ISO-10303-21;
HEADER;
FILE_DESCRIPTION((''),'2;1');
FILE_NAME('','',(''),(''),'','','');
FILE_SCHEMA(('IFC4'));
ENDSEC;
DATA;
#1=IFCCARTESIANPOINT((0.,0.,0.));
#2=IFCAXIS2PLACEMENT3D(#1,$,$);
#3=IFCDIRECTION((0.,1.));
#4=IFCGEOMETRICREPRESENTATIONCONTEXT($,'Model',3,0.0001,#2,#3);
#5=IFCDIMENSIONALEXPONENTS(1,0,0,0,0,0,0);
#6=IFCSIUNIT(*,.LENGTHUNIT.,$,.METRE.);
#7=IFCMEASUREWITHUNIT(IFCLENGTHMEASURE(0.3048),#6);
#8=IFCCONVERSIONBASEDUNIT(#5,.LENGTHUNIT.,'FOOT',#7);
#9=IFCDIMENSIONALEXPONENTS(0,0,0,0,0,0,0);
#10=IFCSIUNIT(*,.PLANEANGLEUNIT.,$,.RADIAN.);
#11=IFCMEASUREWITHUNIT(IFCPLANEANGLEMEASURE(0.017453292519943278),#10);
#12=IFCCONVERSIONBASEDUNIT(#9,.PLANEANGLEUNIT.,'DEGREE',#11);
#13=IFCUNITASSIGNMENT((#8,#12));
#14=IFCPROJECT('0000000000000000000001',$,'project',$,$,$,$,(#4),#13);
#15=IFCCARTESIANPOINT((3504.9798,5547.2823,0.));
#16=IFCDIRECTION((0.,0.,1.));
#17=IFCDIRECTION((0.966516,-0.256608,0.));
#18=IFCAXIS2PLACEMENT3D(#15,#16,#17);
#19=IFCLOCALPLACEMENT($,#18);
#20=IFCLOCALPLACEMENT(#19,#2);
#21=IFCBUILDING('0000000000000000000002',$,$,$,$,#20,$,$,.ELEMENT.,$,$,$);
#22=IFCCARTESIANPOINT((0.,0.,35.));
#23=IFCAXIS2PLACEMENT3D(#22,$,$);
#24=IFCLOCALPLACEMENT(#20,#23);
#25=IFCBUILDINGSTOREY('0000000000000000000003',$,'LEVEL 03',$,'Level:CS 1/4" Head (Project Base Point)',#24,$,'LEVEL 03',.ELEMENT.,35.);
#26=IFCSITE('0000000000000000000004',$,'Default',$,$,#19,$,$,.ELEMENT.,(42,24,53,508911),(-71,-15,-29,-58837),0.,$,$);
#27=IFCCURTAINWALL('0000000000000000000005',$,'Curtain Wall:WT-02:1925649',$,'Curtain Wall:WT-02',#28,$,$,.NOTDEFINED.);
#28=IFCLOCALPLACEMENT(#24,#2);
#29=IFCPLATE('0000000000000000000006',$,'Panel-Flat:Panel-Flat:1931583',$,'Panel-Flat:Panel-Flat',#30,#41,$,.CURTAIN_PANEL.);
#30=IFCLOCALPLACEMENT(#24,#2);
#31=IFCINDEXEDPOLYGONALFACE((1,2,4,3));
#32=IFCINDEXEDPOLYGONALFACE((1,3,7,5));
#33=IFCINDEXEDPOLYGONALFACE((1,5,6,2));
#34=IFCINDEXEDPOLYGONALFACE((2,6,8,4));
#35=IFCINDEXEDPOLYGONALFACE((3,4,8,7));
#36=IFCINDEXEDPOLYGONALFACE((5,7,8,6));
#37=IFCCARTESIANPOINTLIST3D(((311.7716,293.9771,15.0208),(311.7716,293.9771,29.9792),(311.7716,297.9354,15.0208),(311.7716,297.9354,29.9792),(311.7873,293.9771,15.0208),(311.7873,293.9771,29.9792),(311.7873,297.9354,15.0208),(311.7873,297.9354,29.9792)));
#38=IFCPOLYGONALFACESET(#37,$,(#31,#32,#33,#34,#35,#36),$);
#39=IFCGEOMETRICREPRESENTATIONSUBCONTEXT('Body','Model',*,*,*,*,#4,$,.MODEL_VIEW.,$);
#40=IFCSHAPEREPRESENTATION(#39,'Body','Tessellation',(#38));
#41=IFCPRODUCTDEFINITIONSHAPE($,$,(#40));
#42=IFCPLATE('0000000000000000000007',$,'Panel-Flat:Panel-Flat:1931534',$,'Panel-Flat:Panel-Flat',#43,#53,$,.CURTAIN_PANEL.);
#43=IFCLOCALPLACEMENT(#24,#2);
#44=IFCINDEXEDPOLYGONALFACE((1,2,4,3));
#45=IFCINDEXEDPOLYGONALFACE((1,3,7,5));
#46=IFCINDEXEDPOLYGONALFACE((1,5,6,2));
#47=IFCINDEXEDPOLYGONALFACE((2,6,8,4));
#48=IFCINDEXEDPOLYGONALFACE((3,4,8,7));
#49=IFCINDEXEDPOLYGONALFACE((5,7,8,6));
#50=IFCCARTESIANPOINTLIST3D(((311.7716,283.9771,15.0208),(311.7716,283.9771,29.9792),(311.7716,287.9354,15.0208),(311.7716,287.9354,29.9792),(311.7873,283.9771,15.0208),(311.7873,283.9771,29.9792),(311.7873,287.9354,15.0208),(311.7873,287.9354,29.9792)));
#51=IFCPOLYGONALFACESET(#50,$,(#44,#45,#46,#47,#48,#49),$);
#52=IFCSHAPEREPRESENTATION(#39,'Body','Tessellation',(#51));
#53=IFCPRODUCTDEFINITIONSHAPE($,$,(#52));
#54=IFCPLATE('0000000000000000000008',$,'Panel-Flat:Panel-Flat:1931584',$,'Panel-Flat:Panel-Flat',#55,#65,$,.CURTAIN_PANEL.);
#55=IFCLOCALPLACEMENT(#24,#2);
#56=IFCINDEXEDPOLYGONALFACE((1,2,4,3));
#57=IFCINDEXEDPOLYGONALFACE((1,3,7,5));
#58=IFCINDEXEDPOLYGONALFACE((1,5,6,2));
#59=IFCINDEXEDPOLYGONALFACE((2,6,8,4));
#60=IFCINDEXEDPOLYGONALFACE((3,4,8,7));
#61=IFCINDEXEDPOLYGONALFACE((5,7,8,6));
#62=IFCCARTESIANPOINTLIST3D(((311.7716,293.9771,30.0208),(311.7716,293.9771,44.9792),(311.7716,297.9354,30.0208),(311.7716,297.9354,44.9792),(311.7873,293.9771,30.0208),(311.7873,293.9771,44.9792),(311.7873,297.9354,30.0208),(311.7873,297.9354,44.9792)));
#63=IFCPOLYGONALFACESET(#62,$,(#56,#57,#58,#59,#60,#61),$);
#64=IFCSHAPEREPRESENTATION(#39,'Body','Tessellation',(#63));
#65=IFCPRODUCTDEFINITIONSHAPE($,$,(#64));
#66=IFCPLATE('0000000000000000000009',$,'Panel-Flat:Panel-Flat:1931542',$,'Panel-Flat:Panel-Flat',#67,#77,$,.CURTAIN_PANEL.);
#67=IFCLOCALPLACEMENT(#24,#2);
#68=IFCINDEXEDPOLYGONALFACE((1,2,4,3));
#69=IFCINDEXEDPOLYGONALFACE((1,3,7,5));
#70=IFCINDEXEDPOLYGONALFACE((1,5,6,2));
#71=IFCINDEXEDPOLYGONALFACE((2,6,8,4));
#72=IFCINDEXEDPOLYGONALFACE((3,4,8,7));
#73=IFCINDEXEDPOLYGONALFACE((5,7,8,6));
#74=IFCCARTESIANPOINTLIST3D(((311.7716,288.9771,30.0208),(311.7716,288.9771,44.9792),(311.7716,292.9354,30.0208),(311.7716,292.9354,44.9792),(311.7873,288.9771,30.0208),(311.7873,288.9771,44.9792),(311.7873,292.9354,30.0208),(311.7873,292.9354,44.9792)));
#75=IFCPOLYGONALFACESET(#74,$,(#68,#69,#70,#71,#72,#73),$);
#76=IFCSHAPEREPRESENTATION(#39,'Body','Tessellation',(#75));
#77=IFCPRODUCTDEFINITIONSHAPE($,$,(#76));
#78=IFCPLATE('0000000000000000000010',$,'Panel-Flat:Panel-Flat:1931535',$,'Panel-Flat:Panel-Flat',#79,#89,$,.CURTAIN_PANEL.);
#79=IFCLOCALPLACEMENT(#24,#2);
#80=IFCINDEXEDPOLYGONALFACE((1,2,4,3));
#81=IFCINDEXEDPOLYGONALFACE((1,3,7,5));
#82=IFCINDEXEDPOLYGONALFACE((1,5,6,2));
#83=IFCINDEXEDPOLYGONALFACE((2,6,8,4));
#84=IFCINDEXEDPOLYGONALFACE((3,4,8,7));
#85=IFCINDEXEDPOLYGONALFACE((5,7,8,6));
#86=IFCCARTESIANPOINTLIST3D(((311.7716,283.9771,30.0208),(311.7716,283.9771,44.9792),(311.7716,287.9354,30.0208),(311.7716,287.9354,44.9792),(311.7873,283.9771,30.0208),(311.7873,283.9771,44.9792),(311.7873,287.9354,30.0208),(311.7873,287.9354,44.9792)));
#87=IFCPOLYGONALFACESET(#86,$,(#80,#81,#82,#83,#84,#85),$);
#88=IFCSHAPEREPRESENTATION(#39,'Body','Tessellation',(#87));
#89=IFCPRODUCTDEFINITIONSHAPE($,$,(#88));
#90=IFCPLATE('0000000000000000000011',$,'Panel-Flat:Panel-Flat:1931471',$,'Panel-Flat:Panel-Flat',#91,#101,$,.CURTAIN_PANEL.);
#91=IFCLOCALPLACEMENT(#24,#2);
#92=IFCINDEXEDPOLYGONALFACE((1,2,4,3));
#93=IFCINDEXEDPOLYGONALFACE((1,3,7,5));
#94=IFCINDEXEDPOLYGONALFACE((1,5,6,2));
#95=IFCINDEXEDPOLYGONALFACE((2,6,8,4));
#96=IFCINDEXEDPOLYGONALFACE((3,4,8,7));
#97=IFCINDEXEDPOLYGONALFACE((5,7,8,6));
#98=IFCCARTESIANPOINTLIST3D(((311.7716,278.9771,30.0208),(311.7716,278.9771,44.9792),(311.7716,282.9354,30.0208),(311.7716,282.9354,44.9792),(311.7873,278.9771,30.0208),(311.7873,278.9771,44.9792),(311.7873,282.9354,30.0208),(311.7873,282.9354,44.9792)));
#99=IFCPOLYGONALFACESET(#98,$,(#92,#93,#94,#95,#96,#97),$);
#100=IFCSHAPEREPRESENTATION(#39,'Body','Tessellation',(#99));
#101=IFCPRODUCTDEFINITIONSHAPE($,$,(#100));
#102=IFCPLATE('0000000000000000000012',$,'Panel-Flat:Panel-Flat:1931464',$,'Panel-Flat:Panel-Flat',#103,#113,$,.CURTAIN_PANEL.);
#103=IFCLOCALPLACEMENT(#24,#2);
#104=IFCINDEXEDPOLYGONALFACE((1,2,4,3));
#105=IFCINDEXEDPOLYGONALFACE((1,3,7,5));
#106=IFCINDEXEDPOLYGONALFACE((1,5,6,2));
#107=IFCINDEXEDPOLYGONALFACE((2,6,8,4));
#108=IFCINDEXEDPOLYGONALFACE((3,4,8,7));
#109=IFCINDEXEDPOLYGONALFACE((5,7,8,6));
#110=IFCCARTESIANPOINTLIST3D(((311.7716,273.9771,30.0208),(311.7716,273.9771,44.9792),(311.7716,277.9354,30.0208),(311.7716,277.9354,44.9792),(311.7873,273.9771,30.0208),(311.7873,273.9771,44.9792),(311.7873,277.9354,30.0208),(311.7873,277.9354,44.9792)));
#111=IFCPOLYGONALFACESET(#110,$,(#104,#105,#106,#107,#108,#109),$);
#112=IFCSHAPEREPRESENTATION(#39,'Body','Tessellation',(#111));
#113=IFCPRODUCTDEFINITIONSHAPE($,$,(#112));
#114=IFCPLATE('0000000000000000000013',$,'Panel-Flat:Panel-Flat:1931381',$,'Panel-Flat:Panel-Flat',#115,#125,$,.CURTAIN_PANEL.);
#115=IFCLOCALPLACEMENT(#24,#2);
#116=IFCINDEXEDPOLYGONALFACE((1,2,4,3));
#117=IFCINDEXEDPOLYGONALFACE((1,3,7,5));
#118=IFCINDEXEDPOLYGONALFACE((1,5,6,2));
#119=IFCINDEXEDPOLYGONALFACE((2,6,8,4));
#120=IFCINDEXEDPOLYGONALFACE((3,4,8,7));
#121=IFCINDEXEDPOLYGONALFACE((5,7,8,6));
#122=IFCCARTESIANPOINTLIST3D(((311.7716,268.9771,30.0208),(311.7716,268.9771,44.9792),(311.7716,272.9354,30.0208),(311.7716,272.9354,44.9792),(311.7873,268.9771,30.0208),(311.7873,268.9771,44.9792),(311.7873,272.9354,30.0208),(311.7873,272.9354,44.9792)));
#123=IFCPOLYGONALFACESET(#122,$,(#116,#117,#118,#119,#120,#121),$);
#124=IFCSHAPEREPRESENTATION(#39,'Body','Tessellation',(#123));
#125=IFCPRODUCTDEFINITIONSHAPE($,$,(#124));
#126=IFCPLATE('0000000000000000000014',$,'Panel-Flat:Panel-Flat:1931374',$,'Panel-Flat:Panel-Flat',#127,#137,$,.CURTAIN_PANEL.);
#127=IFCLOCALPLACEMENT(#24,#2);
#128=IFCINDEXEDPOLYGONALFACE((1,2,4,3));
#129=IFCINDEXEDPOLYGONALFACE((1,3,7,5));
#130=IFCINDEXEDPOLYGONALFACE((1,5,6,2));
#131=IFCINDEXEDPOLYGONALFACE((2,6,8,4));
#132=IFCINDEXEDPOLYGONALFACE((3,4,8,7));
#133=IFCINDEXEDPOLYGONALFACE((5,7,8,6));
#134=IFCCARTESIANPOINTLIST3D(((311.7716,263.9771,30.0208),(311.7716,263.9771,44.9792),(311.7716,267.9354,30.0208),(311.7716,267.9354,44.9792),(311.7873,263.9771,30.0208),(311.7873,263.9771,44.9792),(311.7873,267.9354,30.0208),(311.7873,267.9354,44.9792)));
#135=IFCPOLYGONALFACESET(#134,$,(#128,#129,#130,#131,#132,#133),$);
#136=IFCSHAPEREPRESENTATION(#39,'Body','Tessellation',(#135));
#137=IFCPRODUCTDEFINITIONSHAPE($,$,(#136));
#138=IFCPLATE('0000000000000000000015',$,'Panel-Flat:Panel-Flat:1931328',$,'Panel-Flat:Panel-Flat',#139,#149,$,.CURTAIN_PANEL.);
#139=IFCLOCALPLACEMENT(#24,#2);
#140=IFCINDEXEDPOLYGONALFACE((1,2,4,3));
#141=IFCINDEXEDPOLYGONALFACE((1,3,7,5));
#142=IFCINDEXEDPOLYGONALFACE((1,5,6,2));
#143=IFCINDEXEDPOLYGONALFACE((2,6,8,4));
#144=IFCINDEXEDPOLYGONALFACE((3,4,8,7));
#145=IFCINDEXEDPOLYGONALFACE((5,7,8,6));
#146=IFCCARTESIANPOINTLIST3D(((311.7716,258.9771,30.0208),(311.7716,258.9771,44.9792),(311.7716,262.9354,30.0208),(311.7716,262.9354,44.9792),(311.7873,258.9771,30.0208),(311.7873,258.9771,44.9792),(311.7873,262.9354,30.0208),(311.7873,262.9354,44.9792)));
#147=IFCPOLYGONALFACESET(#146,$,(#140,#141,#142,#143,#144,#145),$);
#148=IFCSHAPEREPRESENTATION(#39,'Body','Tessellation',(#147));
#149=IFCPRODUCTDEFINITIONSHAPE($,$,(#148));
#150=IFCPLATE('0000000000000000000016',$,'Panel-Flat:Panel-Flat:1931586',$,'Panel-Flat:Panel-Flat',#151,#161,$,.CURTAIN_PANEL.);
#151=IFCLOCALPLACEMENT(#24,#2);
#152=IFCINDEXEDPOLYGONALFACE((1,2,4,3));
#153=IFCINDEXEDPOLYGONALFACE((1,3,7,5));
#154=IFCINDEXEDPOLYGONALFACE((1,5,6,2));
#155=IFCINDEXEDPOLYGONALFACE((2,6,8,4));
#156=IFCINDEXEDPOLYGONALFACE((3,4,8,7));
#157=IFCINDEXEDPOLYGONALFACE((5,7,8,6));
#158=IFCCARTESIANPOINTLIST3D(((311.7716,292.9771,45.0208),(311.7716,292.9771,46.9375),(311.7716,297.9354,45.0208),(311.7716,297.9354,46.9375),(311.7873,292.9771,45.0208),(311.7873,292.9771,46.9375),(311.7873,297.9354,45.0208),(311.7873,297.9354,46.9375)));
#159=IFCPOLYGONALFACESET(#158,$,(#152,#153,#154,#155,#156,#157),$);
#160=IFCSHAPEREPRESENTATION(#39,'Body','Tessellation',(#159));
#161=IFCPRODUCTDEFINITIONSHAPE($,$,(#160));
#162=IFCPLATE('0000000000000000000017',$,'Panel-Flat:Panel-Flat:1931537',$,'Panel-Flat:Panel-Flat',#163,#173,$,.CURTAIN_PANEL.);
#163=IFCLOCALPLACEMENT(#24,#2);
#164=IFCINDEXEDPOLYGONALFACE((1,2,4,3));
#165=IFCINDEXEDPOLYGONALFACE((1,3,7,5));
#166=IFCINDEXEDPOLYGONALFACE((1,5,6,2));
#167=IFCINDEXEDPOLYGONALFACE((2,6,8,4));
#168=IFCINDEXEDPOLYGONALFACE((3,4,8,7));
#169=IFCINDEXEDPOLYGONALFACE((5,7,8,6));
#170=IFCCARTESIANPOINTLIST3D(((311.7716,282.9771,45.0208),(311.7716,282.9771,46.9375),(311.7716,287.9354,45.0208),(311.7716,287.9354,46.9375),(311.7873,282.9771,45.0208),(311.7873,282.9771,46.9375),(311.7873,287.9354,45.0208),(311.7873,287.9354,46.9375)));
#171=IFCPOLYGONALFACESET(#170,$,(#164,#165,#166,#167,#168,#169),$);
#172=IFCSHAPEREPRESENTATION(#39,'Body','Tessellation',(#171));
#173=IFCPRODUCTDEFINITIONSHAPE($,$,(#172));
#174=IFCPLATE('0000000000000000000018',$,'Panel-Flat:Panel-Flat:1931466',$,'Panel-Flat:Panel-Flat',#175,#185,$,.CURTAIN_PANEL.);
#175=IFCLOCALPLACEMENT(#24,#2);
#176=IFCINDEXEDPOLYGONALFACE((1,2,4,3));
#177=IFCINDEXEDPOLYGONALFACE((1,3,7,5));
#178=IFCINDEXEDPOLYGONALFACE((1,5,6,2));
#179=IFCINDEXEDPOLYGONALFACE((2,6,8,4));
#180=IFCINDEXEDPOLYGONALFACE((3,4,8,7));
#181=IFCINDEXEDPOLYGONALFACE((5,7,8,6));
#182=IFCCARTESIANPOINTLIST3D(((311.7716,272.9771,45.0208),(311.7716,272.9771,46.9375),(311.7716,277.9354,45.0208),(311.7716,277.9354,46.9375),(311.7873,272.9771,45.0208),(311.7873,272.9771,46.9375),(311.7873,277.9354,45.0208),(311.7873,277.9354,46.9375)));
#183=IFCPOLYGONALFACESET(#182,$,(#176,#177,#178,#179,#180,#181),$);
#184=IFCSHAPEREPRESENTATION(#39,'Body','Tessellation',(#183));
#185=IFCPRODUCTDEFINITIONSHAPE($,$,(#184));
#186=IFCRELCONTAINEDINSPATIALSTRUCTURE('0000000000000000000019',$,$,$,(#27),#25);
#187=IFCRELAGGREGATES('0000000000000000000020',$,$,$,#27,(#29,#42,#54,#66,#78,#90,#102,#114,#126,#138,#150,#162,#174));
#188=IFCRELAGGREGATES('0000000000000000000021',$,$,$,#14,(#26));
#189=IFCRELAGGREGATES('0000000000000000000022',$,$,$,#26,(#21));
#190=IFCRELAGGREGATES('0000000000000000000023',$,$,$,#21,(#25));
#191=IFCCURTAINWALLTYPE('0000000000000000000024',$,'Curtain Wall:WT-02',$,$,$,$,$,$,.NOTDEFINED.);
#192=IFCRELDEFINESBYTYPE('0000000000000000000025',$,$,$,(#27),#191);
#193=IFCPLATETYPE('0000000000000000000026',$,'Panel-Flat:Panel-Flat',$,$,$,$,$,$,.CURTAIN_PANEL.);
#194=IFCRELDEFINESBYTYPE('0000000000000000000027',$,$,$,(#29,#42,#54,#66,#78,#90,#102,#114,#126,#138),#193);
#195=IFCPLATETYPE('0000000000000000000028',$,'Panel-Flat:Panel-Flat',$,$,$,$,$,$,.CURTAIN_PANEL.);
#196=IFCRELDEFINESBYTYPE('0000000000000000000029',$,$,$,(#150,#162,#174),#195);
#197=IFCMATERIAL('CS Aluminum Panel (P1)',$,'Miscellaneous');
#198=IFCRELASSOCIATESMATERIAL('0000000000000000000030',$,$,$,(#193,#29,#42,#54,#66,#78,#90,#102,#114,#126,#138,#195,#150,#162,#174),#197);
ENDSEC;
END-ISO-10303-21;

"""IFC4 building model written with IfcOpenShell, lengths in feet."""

from ifc_helpers import new_model, entity, si_unit, converted_unit, direction, frame, origin, place, context, subcontext, project, spatial, indexed_curve, outline, extrude, source, transform, mapped, material, type_object, type_shapes, element, aggregate, save


model = new_model("IFC4")

# Units and contexts
model_context = context("Model", 3, precision=0.0001, world=origin(), true_north=direction((0.0, 1.0)))
body_context = subcontext(model_context, "Body", "Model", "MODEL_VIEW")
ifc_project = project(units=[converted_unit("LENGTHUNIT", "FOOT", entity("IfcLengthMeasure", 0.3048), si_unit("LENGTHUNIT", "METRE"), dimensions=[1, 0, 0, 0, 0, 0, 0]), converted_unit("PLANEANGLEUNIT", "DEGREE", entity("IfcPlaneAngleMeasure", 0.017453292519943278), si_unit("PLANEANGLEUNIT", "RADIAN"), dimensions=[0, 0, 0, 0, 0, 0, 0])], contexts=[model_context])

# Site, building, storey
site_placement = place(None, frame((3504.9798, 5547.2823, 0.0), z_axis=(0.0, 0.0, 1.0), x_axis=(0.966516, -0.256608, 0.0)))
site = spatial("IfcSite", under=ifc_project, at=site_placement, Name="Default", CompositionType="ELEMENT", RefLatitude=(42, 24, 53, 508911), RefLongitude=(-71, -15, -29, -58837), RefElevation=0.0)
building_placement = place(site_placement, origin())
building = spatial("IfcBuilding", under=site, at=building_placement, CompositionType="ELEMENT")
storey_placement = place(building_placement, frame((0.0, 0.0, 35.0)))
storey = spatial("IfcBuildingStorey", under=building, at=storey_placement, Name="LEVEL 03", ObjectType="Level:CS 1/4\" Head (Project Base Point)", LongName="LEVEL 03", CompositionType="ELEMENT", Elevation=35.0)

# Curtain wall, plates
curtain_wall_type = type_object("IfcCurtainWallType", Name="Curtain Wall:WT-02", PredefinedType="NOTDEFINED")
curtain_wall_placement = place(storey_placement, frame((0.0, 0.0, -35.0)))
curtain_wall = element("IfcCurtainWall", 1, at=curtain_wall_placement, inside=storey, type_object=curtain_wall_type, Name="Curtain Wall:WT-02:1925649", ObjectType="Curtain Wall:WT-02", PredefinedType="NOTDEFINED")
ifc_material = material(Name="CS Aluminum Panel (P1)", Category="Miscellaneous")
plate_type_1 = type_object("IfcPlateType", Name="Panel-Flat:Panel-Flat", PredefinedType="CURTAIN_PANEL", material=ifc_material)
shared_shape_1 = source(origin(), body_context, "Body", "SweptSolid", [
    extrude(outline(indexed_curve([(-0.0078, -1.9792), (0.0078, -1.9792), (0.0078, 1.9792), (-0.0078, 1.9792), (-0.0078, -1.9792)], self_intersect=False)), frame((1.9792, 0.0078, 0.0), z_axis=(0.0, 0.0, 1.0), x_axis=(0.0, -1.0, 0.0)), (0.0, 0.0, 1.0), 14.9583),
])
type_shapes(plate_type_1, [shared_shape_1])
plate_1_placement = place(curtain_wall_placement, frame((311.7716, 297.9354, 50.0208), z_axis=(0.0, 0.0, 1.0), x_axis=(0.0, -1.0, 0.0)))
plate_1 = element("IfcPlate", 2, at=plate_1_placement, type_object=plate_type_1, material=ifc_material, Name="Panel-Flat:Panel-Flat:1931583", ObjectType="Panel-Flat:Panel-Flat", PredefinedType="CURTAIN_PANEL", context=body_context, shape_type="MappedRepresentation", body=[
    mapped(shared_shape_1, transform((0.0, 0.0, 0.0), scale=1.0)),
])
plate_2_placement = place(curtain_wall_placement, frame((311.7716, 287.9354, 50.0208), z_axis=(0.0, 0.0, 1.0), x_axis=(0.0, -1.0, 0.0)))
plate_2 = element("IfcPlate", 3, at=plate_2_placement, type_object=plate_type_1, material=ifc_material, Name="Panel-Flat:Panel-Flat:1931534", ObjectType="Panel-Flat:Panel-Flat", PredefinedType="CURTAIN_PANEL", context=body_context, shape_type="MappedRepresentation", body=[
    mapped(shared_shape_1, transform((0.0, 0.0, 0.0), scale=1.0)),
])
plate_3_placement = place(curtain_wall_placement, frame((311.7716, 297.9354, 65.0208), z_axis=(0.0, 0.0, 1.0), x_axis=(0.0, -1.0, 0.0)))
plate_3 = element("IfcPlate", 4, at=plate_3_placement, type_object=plate_type_1, material=ifc_material, Name="Panel-Flat:Panel-Flat:1931584", ObjectType="Panel-Flat:Panel-Flat", PredefinedType="CURTAIN_PANEL", context=body_context, shape_type="MappedRepresentation", body=[
    mapped(shared_shape_1, transform((0.0, 0.0, 0.0), scale=1.0)),
])
plate_4_placement = place(curtain_wall_placement, frame((311.7716, 292.9354, 65.0208), z_axis=(0.0, 0.0, 1.0), x_axis=(0.0, -1.0, 0.0)))
plate_4 = element("IfcPlate", 5, at=plate_4_placement, type_object=plate_type_1, material=ifc_material, Name="Panel-Flat:Panel-Flat:1931542", ObjectType="Panel-Flat:Panel-Flat", PredefinedType="CURTAIN_PANEL", context=body_context, shape_type="MappedRepresentation", body=[
    mapped(shared_shape_1, transform((0.0, 0.0, 0.0), scale=1.0)),
])
plate_5_placement = place(curtain_wall_placement, frame((311.7716, 287.9354, 65.0208), z_axis=(0.0, 0.0, 1.0), x_axis=(0.0, -1.0, 0.0)))
plate_5 = element("IfcPlate", 6, at=plate_5_placement, type_object=plate_type_1, material=ifc_material, Name="Panel-Flat:Panel-Flat:1931535", ObjectType="Panel-Flat:Panel-Flat", PredefinedType="CURTAIN_PANEL", context=body_context, shape_type="MappedRepresentation", body=[
    mapped(shared_shape_1, transform((0.0, 0.0, 0.0), scale=1.0)),
])
plate_6_placement = place(curtain_wall_placement, frame((311.7716, 282.9354, 65.0208), z_axis=(0.0, 0.0, 1.0), x_axis=(0.0, -1.0, 0.0)))
plate_6 = element("IfcPlate", 7, at=plate_6_placement, type_object=plate_type_1, material=ifc_material, Name="Panel-Flat:Panel-Flat:1931471", ObjectType="Panel-Flat:Panel-Flat", PredefinedType="CURTAIN_PANEL", context=body_context, shape_type="MappedRepresentation", body=[
    mapped(shared_shape_1, transform((0.0, 0.0, 0.0), scale=1.0)),
])
plate_7_placement = place(curtain_wall_placement, frame((311.7716, 277.9354, 65.0208), z_axis=(0.0, 0.0, 1.0), x_axis=(0.0, -1.0, 0.0)))
plate_7 = element("IfcPlate", 8, at=plate_7_placement, type_object=plate_type_1, material=ifc_material, Name="Panel-Flat:Panel-Flat:1931464", ObjectType="Panel-Flat:Panel-Flat", PredefinedType="CURTAIN_PANEL", context=body_context, shape_type="MappedRepresentation", body=[
    mapped(shared_shape_1, transform((0.0, 0.0, 0.0), scale=1.0)),
])
plate_8_placement = place(curtain_wall_placement, frame((311.7716, 272.9354, 65.0208), z_axis=(0.0, 0.0, 1.0), x_axis=(0.0, -1.0, 0.0)))
plate_8 = element("IfcPlate", 9, at=plate_8_placement, type_object=plate_type_1, material=ifc_material, Name="Panel-Flat:Panel-Flat:1931381", ObjectType="Panel-Flat:Panel-Flat", PredefinedType="CURTAIN_PANEL", context=body_context, shape_type="MappedRepresentation", body=[
    mapped(shared_shape_1, transform((0.0, 0.0, 0.0), scale=1.0)),
])
plate_9_placement = place(curtain_wall_placement, frame((311.7716, 267.9354, 65.0208), z_axis=(0.0, 0.0, 1.0), x_axis=(0.0, -1.0, 0.0)))
plate_9 = element("IfcPlate", 10, at=plate_9_placement, type_object=plate_type_1, material=ifc_material, Name="Panel-Flat:Panel-Flat:1931374", ObjectType="Panel-Flat:Panel-Flat", PredefinedType="CURTAIN_PANEL", context=body_context, shape_type="MappedRepresentation", body=[
    mapped(shared_shape_1, transform((0.0, 0.0, 0.0), scale=1.0)),
])
plate_10_placement = place(curtain_wall_placement, frame((311.7716, 262.9354, 65.0208), z_axis=(0.0, 0.0, 1.0), x_axis=(0.0, -1.0, 0.0)))
plate_10 = element("IfcPlate", 11, at=plate_10_placement, type_object=plate_type_1, material=ifc_material, Name="Panel-Flat:Panel-Flat:1931328", ObjectType="Panel-Flat:Panel-Flat", PredefinedType="CURTAIN_PANEL", context=body_context, shape_type="MappedRepresentation", body=[
    mapped(shared_shape_1, transform((0.0, 0.0, 0.0), scale=1.0)),
])
plate_type_2 = type_object("IfcPlateType", Name="Panel-Flat:Panel-Flat", PredefinedType="CURTAIN_PANEL", material=ifc_material)
shared_shape_2 = source(origin(), body_context, "Body", "SweptSolid", [
    extrude(outline(indexed_curve([(-0.0078, -2.4792), (0.0078, -2.4792), (0.0078, 2.4792), (-0.0078, 2.4792), (-0.0078, -2.4792)], self_intersect=False)), frame((2.4792, 0.0078, 0.0), z_axis=(0.0, 0.0, 1.0), x_axis=(0.0, -1.0, 0.0)), (0.0, 0.0, 1.0), 1.9167),
])
type_shapes(plate_type_2, [shared_shape_2])
plate_11_placement = place(curtain_wall_placement, frame((311.7716, 297.9354, 80.0208), z_axis=(0.0, 0.0, 1.0), x_axis=(0.0, -1.0, 0.0)))
plate_11 = element("IfcPlate", 12, at=plate_11_placement, type_object=plate_type_2, material=ifc_material, Name="Panel-Flat:Panel-Flat:1931586", ObjectType="Panel-Flat:Panel-Flat", PredefinedType="CURTAIN_PANEL", context=body_context, shape_type="MappedRepresentation", body=[
    mapped(shared_shape_2, transform((0.0, 0.0, 0.0), scale=1.0)),
])
plate_12_placement = place(curtain_wall_placement, frame((311.7716, 287.9354, 80.0208), z_axis=(0.0, 0.0, 1.0), x_axis=(0.0, -1.0, 0.0)))
plate_12 = element("IfcPlate", 13, at=plate_12_placement, type_object=plate_type_2, material=ifc_material, Name="Panel-Flat:Panel-Flat:1931537", ObjectType="Panel-Flat:Panel-Flat", PredefinedType="CURTAIN_PANEL", context=body_context, shape_type="MappedRepresentation", body=[
    mapped(shared_shape_2, transform((0.0, 0.0, 0.0), scale=1.0)),
])
plate_13_placement = place(curtain_wall_placement, frame((311.7716, 277.9354, 80.0208), z_axis=(0.0, 0.0, 1.0), x_axis=(0.0, -1.0, 0.0)))
plate_13 = element("IfcPlate", 14, at=plate_13_placement, type_object=plate_type_2, material=ifc_material, Name="Panel-Flat:Panel-Flat:1931466", ObjectType="Panel-Flat:Panel-Flat", PredefinedType="CURTAIN_PANEL", context=body_context, shape_type="MappedRepresentation", body=[
    mapped(shared_shape_2, transform((0.0, 0.0, 0.0), scale=1.0)),
])
aggregate(curtain_wall, [plate_1, plate_2, plate_3, plate_4, plate_5, plate_6, plate_7, plate_8, plate_9, plate_10, plate_11, plate_12, plate_13])

save(model, "model.ifc")
